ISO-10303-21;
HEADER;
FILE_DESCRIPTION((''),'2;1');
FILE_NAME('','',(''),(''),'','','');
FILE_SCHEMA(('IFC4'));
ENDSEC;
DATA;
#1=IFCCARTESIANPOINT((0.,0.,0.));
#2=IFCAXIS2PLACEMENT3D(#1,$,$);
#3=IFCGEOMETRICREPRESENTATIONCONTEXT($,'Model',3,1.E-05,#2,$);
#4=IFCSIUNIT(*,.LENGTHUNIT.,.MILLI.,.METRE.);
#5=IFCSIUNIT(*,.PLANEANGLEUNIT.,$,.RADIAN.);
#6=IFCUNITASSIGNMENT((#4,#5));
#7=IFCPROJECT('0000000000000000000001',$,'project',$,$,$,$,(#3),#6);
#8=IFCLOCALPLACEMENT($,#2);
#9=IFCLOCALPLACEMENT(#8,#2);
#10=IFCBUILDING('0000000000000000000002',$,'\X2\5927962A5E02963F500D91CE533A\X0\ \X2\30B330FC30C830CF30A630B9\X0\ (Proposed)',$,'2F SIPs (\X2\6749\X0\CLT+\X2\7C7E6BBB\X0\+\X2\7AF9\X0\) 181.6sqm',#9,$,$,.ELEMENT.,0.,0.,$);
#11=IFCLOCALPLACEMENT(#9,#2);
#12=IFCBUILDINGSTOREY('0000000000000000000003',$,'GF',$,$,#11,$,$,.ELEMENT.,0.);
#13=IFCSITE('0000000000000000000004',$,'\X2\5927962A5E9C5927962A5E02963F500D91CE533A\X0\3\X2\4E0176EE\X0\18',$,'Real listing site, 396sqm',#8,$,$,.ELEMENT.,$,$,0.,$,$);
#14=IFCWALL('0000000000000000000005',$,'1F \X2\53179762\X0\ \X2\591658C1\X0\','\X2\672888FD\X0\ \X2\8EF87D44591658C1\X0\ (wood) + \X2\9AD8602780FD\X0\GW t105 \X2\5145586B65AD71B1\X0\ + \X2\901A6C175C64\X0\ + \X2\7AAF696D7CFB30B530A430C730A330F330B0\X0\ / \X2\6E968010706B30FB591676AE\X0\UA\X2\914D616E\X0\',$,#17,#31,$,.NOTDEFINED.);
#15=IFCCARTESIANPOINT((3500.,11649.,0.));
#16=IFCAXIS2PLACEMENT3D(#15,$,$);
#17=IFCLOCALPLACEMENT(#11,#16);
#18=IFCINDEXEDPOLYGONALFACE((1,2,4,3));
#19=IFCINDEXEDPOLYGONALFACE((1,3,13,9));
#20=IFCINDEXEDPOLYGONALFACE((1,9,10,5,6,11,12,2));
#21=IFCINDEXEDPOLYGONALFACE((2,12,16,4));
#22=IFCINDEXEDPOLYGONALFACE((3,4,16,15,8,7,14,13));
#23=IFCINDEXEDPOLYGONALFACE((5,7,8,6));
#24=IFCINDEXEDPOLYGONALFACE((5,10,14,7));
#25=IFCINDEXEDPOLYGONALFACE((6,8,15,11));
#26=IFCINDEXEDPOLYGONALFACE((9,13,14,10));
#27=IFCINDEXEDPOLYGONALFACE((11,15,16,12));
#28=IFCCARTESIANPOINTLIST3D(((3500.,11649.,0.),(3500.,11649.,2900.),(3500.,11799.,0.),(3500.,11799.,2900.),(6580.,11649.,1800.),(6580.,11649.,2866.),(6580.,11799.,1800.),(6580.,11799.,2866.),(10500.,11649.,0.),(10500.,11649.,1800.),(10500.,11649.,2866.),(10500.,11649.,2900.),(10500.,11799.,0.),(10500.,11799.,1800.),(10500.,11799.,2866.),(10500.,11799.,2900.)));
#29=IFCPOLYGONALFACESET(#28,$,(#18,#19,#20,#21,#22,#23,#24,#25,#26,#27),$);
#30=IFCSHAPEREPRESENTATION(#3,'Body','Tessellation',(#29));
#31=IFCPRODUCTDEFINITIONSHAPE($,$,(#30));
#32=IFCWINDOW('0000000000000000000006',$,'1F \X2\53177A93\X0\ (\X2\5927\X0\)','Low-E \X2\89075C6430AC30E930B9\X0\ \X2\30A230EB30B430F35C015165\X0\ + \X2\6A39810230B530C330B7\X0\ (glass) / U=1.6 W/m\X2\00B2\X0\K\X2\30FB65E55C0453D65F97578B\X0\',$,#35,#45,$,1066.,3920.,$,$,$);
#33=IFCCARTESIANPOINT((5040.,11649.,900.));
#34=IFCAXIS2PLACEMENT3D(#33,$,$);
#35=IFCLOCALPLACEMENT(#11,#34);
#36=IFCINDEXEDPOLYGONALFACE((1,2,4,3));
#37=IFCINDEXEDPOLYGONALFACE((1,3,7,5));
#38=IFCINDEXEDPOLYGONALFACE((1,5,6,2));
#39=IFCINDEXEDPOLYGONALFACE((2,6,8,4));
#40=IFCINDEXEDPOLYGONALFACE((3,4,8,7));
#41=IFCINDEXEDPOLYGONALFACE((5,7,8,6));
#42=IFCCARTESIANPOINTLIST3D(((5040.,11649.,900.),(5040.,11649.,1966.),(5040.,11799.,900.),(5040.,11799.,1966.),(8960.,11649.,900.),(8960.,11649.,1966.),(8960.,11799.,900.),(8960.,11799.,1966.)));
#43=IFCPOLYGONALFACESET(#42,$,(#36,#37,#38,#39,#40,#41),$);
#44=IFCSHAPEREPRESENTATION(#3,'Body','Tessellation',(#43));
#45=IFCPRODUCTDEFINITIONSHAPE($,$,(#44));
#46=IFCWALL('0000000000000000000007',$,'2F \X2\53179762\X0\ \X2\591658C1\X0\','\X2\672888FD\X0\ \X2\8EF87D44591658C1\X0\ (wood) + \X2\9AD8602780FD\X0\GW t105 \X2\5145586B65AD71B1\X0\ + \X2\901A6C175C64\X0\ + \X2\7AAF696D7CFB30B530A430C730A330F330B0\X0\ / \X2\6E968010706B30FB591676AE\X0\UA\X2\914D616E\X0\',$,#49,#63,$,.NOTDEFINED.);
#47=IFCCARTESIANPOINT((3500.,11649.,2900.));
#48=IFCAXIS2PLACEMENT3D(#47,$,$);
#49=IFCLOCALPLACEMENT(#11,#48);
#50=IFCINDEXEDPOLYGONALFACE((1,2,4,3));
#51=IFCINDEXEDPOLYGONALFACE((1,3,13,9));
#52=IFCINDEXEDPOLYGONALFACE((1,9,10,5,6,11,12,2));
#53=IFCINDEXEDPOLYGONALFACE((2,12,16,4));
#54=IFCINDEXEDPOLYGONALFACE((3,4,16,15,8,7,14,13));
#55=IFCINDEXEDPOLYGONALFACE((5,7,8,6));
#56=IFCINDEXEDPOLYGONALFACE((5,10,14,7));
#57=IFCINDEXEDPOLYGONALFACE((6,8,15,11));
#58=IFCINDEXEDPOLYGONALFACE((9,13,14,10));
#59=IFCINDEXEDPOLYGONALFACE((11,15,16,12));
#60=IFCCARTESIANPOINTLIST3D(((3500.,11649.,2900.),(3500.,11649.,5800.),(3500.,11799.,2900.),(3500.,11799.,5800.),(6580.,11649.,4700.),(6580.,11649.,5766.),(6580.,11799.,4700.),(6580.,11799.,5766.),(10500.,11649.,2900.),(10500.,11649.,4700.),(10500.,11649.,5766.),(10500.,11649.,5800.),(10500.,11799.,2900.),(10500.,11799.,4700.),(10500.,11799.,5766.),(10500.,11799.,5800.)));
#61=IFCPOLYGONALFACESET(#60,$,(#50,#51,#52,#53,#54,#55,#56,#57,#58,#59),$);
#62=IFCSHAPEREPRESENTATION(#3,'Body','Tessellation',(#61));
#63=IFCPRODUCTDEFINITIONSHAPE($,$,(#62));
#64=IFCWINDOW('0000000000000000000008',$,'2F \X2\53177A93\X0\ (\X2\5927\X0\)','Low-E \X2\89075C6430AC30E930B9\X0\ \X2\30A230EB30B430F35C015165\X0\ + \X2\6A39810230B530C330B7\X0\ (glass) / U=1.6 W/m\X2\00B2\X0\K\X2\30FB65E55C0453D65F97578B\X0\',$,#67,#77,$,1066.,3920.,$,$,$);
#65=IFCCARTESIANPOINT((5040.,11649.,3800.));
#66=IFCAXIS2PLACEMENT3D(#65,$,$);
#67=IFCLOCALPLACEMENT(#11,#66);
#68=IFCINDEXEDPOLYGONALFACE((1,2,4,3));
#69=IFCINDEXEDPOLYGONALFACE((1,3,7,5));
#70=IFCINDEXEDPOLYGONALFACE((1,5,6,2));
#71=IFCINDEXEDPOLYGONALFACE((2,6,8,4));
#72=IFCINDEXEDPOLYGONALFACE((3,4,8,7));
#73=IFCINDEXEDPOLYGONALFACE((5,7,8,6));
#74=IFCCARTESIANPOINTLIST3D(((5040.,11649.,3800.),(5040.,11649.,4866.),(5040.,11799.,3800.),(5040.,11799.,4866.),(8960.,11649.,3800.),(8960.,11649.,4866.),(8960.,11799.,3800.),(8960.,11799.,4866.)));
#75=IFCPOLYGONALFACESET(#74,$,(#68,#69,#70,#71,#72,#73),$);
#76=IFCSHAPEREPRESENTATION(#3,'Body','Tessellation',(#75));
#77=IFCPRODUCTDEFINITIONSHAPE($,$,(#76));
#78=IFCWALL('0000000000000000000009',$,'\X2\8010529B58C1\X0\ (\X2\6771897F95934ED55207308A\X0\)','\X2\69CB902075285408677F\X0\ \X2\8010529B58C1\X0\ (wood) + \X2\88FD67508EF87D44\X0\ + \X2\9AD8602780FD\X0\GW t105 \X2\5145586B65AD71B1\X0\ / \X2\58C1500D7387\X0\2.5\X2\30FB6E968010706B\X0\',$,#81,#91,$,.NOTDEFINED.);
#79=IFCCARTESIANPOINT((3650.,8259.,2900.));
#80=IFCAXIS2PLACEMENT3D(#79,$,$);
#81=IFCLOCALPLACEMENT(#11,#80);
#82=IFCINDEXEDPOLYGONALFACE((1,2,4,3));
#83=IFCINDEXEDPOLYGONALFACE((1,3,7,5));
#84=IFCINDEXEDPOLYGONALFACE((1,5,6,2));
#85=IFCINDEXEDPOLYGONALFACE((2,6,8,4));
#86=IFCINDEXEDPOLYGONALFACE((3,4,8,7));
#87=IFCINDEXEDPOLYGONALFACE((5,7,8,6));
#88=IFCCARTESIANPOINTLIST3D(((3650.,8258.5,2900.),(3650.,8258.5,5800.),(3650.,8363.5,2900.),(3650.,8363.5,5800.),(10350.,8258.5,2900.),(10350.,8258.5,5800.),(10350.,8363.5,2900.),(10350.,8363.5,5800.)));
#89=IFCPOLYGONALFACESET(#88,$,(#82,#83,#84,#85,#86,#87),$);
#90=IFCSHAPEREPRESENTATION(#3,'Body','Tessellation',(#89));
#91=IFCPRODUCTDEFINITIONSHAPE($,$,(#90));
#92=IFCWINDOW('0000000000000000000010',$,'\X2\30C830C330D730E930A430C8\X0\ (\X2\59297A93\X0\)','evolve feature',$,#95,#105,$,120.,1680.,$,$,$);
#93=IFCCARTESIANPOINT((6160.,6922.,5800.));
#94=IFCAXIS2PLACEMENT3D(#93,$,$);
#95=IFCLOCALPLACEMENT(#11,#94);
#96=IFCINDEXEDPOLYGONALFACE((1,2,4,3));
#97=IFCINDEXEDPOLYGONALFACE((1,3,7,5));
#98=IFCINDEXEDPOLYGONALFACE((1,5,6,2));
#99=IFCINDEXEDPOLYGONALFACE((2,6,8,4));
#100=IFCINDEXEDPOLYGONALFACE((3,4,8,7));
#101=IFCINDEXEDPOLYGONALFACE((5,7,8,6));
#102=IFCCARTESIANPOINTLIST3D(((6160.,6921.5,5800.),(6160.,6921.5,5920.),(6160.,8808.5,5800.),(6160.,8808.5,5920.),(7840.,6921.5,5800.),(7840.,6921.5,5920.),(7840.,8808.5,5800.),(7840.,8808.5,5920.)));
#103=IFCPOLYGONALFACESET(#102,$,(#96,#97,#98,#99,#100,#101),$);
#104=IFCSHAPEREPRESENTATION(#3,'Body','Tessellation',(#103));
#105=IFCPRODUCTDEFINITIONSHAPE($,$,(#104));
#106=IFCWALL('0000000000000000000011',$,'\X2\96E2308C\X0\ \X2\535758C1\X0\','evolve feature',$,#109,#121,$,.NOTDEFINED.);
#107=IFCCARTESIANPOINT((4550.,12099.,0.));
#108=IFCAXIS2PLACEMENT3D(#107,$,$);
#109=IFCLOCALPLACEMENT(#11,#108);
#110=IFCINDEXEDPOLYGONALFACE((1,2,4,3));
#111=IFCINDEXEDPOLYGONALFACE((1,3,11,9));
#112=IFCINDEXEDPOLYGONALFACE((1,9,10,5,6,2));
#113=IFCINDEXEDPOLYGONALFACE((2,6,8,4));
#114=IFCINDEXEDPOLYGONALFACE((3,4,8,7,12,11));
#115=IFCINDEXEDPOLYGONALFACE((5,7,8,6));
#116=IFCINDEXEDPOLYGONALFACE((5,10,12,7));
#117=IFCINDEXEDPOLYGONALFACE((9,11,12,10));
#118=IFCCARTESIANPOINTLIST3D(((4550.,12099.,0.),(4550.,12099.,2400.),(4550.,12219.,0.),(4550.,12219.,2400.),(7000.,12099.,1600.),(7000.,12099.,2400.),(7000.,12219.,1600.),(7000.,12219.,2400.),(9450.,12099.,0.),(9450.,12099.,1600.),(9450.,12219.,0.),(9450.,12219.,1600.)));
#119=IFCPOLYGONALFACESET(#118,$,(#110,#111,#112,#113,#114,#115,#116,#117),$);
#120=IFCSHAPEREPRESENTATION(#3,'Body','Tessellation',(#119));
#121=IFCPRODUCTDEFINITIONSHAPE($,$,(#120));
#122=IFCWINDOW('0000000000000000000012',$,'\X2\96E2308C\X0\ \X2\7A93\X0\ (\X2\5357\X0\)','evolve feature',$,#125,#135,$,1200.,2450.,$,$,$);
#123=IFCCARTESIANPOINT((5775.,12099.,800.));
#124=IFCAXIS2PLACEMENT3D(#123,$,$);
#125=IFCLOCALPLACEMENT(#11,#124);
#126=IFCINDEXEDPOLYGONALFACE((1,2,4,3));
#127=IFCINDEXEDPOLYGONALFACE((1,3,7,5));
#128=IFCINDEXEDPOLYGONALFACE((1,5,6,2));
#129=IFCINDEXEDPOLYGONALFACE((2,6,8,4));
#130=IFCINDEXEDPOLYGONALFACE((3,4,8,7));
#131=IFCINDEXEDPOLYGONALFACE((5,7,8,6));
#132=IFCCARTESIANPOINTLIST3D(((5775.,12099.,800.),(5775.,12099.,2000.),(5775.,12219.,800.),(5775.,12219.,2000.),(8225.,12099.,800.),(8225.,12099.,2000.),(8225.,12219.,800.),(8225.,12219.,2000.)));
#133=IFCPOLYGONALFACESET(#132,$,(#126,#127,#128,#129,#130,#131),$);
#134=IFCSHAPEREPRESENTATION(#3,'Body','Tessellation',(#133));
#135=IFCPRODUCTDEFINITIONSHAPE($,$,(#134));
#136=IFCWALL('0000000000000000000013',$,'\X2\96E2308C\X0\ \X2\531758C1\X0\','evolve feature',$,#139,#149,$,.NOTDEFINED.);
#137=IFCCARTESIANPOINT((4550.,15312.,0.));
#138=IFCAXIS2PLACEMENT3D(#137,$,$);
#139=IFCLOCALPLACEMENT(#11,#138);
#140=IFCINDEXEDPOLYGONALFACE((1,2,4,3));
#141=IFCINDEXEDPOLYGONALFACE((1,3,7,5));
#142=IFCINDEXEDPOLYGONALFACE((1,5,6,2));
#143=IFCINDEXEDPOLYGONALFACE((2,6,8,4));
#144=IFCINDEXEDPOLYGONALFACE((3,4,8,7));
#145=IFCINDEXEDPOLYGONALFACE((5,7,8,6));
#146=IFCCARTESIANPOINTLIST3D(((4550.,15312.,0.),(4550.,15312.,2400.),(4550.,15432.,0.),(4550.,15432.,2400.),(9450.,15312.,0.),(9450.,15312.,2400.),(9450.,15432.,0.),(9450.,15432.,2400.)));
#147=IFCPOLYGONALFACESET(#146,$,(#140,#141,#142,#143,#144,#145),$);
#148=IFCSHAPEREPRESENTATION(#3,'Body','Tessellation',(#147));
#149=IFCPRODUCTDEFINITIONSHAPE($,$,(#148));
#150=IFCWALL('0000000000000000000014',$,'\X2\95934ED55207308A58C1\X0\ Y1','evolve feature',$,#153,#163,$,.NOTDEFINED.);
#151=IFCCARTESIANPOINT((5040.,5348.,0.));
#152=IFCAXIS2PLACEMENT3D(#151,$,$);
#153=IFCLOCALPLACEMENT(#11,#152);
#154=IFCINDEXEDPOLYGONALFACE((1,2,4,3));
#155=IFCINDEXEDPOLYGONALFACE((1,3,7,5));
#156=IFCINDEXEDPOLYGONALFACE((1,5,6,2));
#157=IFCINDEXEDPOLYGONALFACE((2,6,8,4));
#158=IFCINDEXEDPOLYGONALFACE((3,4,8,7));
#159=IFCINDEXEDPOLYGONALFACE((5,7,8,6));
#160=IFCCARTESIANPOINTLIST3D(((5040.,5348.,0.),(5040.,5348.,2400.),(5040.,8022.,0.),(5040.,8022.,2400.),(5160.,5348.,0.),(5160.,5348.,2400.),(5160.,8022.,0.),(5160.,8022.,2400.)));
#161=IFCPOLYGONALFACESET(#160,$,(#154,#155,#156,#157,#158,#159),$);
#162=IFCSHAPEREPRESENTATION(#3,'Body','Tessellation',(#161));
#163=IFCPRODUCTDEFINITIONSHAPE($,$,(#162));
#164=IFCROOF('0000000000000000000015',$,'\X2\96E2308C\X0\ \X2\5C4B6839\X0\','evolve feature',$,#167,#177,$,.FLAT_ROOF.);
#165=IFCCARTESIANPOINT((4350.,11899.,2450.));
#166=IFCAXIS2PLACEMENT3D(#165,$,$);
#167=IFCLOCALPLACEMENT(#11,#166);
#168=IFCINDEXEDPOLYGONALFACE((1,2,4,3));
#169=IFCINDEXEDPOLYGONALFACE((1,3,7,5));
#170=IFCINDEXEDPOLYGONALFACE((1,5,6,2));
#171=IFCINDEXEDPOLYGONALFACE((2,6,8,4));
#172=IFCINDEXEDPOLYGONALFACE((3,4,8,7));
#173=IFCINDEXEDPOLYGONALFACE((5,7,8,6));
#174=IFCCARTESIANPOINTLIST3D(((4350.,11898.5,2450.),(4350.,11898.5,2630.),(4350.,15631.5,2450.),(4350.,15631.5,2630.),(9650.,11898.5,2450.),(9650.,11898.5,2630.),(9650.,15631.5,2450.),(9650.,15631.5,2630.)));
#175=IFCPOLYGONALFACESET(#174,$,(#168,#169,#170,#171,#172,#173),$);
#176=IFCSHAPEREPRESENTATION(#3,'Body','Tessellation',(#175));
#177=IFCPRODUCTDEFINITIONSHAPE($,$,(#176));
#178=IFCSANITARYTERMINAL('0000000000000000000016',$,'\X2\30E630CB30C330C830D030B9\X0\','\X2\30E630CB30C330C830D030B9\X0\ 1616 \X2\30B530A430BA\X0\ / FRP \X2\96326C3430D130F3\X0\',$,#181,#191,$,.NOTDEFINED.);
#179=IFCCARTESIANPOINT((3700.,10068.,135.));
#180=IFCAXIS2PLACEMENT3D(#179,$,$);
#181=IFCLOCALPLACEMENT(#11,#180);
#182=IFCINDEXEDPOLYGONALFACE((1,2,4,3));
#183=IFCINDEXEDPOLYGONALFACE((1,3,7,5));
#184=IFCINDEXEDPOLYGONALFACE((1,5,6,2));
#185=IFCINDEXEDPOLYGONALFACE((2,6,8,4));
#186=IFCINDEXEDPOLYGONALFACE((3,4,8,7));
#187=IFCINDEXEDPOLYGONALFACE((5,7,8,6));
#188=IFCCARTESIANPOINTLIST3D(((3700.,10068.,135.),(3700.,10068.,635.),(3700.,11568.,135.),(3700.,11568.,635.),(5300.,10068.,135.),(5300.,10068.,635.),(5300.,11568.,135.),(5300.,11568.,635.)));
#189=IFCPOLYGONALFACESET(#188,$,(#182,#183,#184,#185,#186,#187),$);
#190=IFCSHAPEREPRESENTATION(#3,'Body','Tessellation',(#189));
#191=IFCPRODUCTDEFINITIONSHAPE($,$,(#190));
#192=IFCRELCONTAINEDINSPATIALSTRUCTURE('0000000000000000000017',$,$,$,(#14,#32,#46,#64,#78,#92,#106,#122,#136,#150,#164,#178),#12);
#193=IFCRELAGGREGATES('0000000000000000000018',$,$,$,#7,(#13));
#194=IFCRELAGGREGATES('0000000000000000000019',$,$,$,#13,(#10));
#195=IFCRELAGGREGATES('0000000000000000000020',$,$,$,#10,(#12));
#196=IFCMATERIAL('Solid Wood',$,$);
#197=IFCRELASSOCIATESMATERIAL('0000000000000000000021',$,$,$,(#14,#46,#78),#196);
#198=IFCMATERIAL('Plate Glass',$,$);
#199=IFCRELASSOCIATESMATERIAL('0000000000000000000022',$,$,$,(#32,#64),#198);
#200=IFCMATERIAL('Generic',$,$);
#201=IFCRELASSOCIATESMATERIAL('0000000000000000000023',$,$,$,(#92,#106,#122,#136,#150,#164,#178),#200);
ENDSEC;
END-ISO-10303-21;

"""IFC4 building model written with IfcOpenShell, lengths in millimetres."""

from ifc_helpers import new_model, si_unit, frame, frame_2d, origin, place, context, project, spatial, rectangle, extrude, material, element, fill, save


model = new_model("IFC4")

# Units and contexts
model_context = context("Model", 3, precision=1e-05, world=origin())
ifc_project = project(units=[si_unit("LENGTHUNIT", "METRE", prefix="MILLI"), si_unit("PLANEANGLEUNIT", "RADIAN")], contexts=[model_context])

# Site, building, storey
site_placement = place(None, origin())
site = spatial("IfcSite", under=ifc_project, at=site_placement, Name="大阪府大阪市阿倍野区3丁目18", ObjectType="Real listing site, 396sqm", CompositionType="ELEMENT", RefElevation=0.0)
building_placement = place(site_placement, origin())
building = spatial("IfcBuilding", under=site, at=building_placement, Name="大阪市阿倍野区 コートハウス (Proposed)", ObjectType="2F SIPs (杉CLT+籾殻+竹) 181.6sqm", CompositionType="ELEMENT", ElevationOfRefHeight=0.0, ElevationOfTerrain=0.0)
storey_placement = place(building_placement, origin())
storey = spatial("IfcBuildingStorey", under=building, at=storey_placement, Name="GF", CompositionType="ELEMENT", Elevation=0.0)

# Shared definitions
ifc_material_1 = material(Name="Generic")

# Wall, opening, window
ifc_material_2 = material(Name="Solid Wood")
wall_1_placement = place(storey_placement, frame((3500.0, 11649.0, 0.0)))
wall_1 = element("IfcWall", 1, at=wall_1_placement, inside=storey, material=ifc_material_2, Name="1F 北面 外壁", Description="木製 軸組外壁 (wood) + 高性能GW t105 充填断熱 + 通気層 + 窯業系サイディング / 準耐火・外皮UA配慮", PredefinedType="NOTDEFINED", context=model_context, shape_type="SweptSolid", body=[
    extrude(rectangle(XDim=7000.0, YDim=150.0, at=frame_2d((3500.0, 75.0))), frame((3500.0, 11649.0, 0.0)), (0.0, 0.0, 1.0), 2900.0),
])
opening_1_placement = place(storey_placement, frame((5040.0, 11649.0, 900.0)))
opening_1 = element("IfcOpeningElement", 2, at=opening_1_placement, cuts=wall_1, PredefinedType="NOTDEFINED", context=model_context, shape_type="SweptSolid", body=[
    extrude(rectangle(XDim=3920.0, YDim=150.0, at=frame_2d((1960.0, 75.0))), frame((5040.0, 11649.0, 900.0)), (0.0, 0.0, 1.0), 1066.0),
])
ifc_material_3 = material(Name="Plate Glass")
window_1_placement = place(storey_placement, frame((5040.0, 11649.0, 900.0)))
window_1 = element("IfcWindow", 3, at=window_1_placement, inside=storey, material=ifc_material_3, Name="1F 北窓 (大)", Description="Low-E 複層ガラス アルゴン封入 + 樹脂サッシ (glass) / U=1.6 W/m²K・日射取得型", OverallHeight=1066.0, OverallWidth=3920.0, context=model_context, shape_type="SweptSolid", body=[
    extrude(rectangle(XDim=3920.0, YDim=150.0, at=frame_2d((1960.0, 75.0))), frame((5040.0, 11649.0, 900.0)), (0.0, 0.0, 1.0), 1066.0),
])
fill(opening_1, window_1)

# Wall, opening, window
wall_2_placement = place(storey_placement, frame((3500.0, 11649.0, 2900.0)))
wall_2 = element("IfcWall", 4, at=wall_2_placement, inside=storey, material=ifc_material_2, Name="2F 北面 外壁", Description="木製 軸組外壁 (wood) + 高性能GW t105 充填断熱 + 通気層 + 窯業系サイディング / 準耐火・外皮UA配慮", PredefinedType="NOTDEFINED", context=model_context, shape_type="SweptSolid", body=[
    extrude(rectangle(XDim=7000.0, YDim=150.0, at=frame_2d((3500.0, 75.0))), frame((3500.0, 11649.0, 2900.0)), (0.0, 0.0, 1.0), 2900.0),
])
opening_2_placement = place(storey_placement, frame((5040.0, 11649.0, 3800.0)))
opening_2 = element("IfcOpeningElement", 5, at=opening_2_placement, cuts=wall_2, PredefinedType="NOTDEFINED", context=model_context, shape_type="SweptSolid", body=[
    extrude(rectangle(XDim=3920.0, YDim=150.0, at=frame_2d((1960.0, 75.0))), frame((5040.0, 11649.0, 3800.0)), (0.0, 0.0, 1.0), 1066.0),
])
window_2_placement = place(storey_placement, frame((5040.0, 11649.0, 3800.0)))
window_2 = element("IfcWindow", 6, at=window_2_placement, inside=storey, material=ifc_material_3, Name="2F 北窓 (大)", Description="Low-E 複層ガラス アルゴン封入 + 樹脂サッシ (glass) / U=1.6 W/m²K・日射取得型", OverallHeight=1066.0, OverallWidth=3920.0, context=model_context, shape_type="SweptSolid", body=[
    extrude(rectangle(XDim=3920.0, YDim=150.0, at=frame_2d((1960.0, 75.0))), frame((5040.0, 11649.0, 3800.0)), (0.0, 0.0, 1.0), 1066.0),
])
fill(opening_2, window_2)

# Wall
wall_3_placement = place(storey_placement, frame((3650.0, 8259.0, 2900.0)))
element("IfcWall", 7, at=wall_3_placement, inside=storey, material=ifc_material_2, Name="耐力壁 (東西間仕切り)", Description="構造用合板 耐力壁 (wood) + 製材軸組 + 高性能GW t105 充填断熱 / 壁倍率2.5・準耐火", PredefinedType="NOTDEFINED", context=model_context, shape_type="SweptSolid", body=[
    extrude(rectangle(XDim=6700.0, YDim=105.0, at=frame_2d((3350.0, 52.0))), frame((3650.0, 8259.0, 2900.0)), (0.0, 0.0, 1.0), 2900.0),
])

# Window
window_3_placement = place(storey_placement, frame((6160.0, 6922.0, 5800.0)))
element("IfcWindow", 8, at=window_3_placement, inside=storey, material=ifc_material_1, Name="トップライト (天窓)", Description="evolve feature", OverallHeight=120.0, OverallWidth=1680.0, context=model_context, shape_type="SweptSolid", body=[
    extrude(rectangle(XDim=1680.0, YDim=1887.0, at=frame_2d((840.0, 943.0))), frame((6160.0, 6922.0, 5800.0)), (0.0, 0.0, 1.0), 120.0),
])

# Wall, opening, window
wall_4_placement = place(storey_placement, frame((4550.0, 12099.0, 0.0)))
wall_4 = element("IfcWall", 9, at=wall_4_placement, inside=storey, material=ifc_material_1, Name="離れ 南壁", Description="evolve feature", PredefinedType="NOTDEFINED", context=model_context, shape_type="SweptSolid", body=[
    extrude(rectangle(XDim=4900.0, YDim=120.0, at=frame_2d((2450.0, 60.0))), frame((4550.0, 12099.0, 0.0)), (0.0, 0.0, 1.0), 2400.0),
])
opening_3_placement = place(storey_placement, frame((5775.0, 12099.0, 800.0)))
opening_3 = element("IfcOpeningElement", 10, at=opening_3_placement, cuts=wall_4, PredefinedType="NOTDEFINED", context=model_context, shape_type="SweptSolid", body=[
    extrude(rectangle(XDim=2450.0, YDim=120.0, at=frame_2d((1225.0, 60.0))), frame((5775.0, 12099.0, 800.0)), (0.0, 0.0, 1.0), 1200.0),
])
window_4_placement = place(storey_placement, frame((5775.0, 12099.0, 800.0)))
window_4 = element("IfcWindow", 11, at=window_4_placement, inside=storey, material=ifc_material_1, Name="離れ 窓 (南)", Description="evolve feature", OverallHeight=1200.0, OverallWidth=2450.0, context=model_context, shape_type="SweptSolid", body=[
    extrude(rectangle(XDim=2450.0, YDim=120.0, at=frame_2d((1225.0, 60.0))), frame((5775.0, 12099.0, 800.0)), (0.0, 0.0, 1.0), 1200.0),
])
fill(opening_3, window_4)

# Walls
wall_5_placement = place(storey_placement, frame((4550.0, 15312.0, 0.0)))
element("IfcWall", 12, at=wall_5_placement, inside=storey, material=ifc_material_1, Name="離れ 北壁", Description="evolve feature", PredefinedType="NOTDEFINED", context=model_context, shape_type="SweptSolid", body=[
    extrude(rectangle(XDim=4900.0, YDim=120.0, at=frame_2d((2450.0, 60.0))), frame((4550.0, 15312.0, 0.0)), (0.0, 0.0, 1.0), 2400.0),
])
wall_6_placement = place(storey_placement, frame((5040.0, 5348.0, 0.0)))
element("IfcWall", 13, at=wall_6_placement, inside=storey, material=ifc_material_1, Name="間仕切り壁 Y1", Description="evolve feature", PredefinedType="NOTDEFINED", context=model_context, shape_type="SweptSolid", body=[
    extrude(rectangle(XDim=120.0, YDim=2674.0, at=frame_2d((60.0, 1337.0))), frame((5040.0, 5348.0, 0.0)), (0.0, 0.0, 1.0), 2400.0),
])

# Roof
roof_placement = place(storey_placement, frame((4350.0, 11899.0, 2450.0)))
element("IfcRoof", 14, at=roof_placement, inside=storey, material=ifc_material_1, Name="離れ 屋根", Description="evolve feature", PredefinedType="FLAT_ROOF", context=model_context, shape_type="SweptSolid", body=[
    extrude(rectangle(XDim=5300.0, YDim=3733.0, at=frame_2d((2650.0, 1866.0))), frame((4350.0, 11899.0, 2450.0)), (0.0, 0.0, 1.0), 180.0),
])

# Sanitary terminal
sanitary_terminal_1_placement = place(storey_placement, frame((3700.0, 10068.0, 135.0)))
element("IfcSanitaryTerminal", 15, at=sanitary_terminal_1_placement, inside=storey, material=ifc_material_1, Name="ユニットバス", Description="ユニットバス 1616 サイズ / FRP 防水パン", PredefinedType="NOTDEFINED", context=model_context, shape_type="SweptSolid", body=[
    extrude(rectangle(XDim=1600.0, YDim=1500.0, at=frame_2d((800.0, 750.0))), frame((3700.0, 10068.0, 135.0)), (0.0, 0.0, 1.0), 500.0),
])

save(model, "model.ifc")
